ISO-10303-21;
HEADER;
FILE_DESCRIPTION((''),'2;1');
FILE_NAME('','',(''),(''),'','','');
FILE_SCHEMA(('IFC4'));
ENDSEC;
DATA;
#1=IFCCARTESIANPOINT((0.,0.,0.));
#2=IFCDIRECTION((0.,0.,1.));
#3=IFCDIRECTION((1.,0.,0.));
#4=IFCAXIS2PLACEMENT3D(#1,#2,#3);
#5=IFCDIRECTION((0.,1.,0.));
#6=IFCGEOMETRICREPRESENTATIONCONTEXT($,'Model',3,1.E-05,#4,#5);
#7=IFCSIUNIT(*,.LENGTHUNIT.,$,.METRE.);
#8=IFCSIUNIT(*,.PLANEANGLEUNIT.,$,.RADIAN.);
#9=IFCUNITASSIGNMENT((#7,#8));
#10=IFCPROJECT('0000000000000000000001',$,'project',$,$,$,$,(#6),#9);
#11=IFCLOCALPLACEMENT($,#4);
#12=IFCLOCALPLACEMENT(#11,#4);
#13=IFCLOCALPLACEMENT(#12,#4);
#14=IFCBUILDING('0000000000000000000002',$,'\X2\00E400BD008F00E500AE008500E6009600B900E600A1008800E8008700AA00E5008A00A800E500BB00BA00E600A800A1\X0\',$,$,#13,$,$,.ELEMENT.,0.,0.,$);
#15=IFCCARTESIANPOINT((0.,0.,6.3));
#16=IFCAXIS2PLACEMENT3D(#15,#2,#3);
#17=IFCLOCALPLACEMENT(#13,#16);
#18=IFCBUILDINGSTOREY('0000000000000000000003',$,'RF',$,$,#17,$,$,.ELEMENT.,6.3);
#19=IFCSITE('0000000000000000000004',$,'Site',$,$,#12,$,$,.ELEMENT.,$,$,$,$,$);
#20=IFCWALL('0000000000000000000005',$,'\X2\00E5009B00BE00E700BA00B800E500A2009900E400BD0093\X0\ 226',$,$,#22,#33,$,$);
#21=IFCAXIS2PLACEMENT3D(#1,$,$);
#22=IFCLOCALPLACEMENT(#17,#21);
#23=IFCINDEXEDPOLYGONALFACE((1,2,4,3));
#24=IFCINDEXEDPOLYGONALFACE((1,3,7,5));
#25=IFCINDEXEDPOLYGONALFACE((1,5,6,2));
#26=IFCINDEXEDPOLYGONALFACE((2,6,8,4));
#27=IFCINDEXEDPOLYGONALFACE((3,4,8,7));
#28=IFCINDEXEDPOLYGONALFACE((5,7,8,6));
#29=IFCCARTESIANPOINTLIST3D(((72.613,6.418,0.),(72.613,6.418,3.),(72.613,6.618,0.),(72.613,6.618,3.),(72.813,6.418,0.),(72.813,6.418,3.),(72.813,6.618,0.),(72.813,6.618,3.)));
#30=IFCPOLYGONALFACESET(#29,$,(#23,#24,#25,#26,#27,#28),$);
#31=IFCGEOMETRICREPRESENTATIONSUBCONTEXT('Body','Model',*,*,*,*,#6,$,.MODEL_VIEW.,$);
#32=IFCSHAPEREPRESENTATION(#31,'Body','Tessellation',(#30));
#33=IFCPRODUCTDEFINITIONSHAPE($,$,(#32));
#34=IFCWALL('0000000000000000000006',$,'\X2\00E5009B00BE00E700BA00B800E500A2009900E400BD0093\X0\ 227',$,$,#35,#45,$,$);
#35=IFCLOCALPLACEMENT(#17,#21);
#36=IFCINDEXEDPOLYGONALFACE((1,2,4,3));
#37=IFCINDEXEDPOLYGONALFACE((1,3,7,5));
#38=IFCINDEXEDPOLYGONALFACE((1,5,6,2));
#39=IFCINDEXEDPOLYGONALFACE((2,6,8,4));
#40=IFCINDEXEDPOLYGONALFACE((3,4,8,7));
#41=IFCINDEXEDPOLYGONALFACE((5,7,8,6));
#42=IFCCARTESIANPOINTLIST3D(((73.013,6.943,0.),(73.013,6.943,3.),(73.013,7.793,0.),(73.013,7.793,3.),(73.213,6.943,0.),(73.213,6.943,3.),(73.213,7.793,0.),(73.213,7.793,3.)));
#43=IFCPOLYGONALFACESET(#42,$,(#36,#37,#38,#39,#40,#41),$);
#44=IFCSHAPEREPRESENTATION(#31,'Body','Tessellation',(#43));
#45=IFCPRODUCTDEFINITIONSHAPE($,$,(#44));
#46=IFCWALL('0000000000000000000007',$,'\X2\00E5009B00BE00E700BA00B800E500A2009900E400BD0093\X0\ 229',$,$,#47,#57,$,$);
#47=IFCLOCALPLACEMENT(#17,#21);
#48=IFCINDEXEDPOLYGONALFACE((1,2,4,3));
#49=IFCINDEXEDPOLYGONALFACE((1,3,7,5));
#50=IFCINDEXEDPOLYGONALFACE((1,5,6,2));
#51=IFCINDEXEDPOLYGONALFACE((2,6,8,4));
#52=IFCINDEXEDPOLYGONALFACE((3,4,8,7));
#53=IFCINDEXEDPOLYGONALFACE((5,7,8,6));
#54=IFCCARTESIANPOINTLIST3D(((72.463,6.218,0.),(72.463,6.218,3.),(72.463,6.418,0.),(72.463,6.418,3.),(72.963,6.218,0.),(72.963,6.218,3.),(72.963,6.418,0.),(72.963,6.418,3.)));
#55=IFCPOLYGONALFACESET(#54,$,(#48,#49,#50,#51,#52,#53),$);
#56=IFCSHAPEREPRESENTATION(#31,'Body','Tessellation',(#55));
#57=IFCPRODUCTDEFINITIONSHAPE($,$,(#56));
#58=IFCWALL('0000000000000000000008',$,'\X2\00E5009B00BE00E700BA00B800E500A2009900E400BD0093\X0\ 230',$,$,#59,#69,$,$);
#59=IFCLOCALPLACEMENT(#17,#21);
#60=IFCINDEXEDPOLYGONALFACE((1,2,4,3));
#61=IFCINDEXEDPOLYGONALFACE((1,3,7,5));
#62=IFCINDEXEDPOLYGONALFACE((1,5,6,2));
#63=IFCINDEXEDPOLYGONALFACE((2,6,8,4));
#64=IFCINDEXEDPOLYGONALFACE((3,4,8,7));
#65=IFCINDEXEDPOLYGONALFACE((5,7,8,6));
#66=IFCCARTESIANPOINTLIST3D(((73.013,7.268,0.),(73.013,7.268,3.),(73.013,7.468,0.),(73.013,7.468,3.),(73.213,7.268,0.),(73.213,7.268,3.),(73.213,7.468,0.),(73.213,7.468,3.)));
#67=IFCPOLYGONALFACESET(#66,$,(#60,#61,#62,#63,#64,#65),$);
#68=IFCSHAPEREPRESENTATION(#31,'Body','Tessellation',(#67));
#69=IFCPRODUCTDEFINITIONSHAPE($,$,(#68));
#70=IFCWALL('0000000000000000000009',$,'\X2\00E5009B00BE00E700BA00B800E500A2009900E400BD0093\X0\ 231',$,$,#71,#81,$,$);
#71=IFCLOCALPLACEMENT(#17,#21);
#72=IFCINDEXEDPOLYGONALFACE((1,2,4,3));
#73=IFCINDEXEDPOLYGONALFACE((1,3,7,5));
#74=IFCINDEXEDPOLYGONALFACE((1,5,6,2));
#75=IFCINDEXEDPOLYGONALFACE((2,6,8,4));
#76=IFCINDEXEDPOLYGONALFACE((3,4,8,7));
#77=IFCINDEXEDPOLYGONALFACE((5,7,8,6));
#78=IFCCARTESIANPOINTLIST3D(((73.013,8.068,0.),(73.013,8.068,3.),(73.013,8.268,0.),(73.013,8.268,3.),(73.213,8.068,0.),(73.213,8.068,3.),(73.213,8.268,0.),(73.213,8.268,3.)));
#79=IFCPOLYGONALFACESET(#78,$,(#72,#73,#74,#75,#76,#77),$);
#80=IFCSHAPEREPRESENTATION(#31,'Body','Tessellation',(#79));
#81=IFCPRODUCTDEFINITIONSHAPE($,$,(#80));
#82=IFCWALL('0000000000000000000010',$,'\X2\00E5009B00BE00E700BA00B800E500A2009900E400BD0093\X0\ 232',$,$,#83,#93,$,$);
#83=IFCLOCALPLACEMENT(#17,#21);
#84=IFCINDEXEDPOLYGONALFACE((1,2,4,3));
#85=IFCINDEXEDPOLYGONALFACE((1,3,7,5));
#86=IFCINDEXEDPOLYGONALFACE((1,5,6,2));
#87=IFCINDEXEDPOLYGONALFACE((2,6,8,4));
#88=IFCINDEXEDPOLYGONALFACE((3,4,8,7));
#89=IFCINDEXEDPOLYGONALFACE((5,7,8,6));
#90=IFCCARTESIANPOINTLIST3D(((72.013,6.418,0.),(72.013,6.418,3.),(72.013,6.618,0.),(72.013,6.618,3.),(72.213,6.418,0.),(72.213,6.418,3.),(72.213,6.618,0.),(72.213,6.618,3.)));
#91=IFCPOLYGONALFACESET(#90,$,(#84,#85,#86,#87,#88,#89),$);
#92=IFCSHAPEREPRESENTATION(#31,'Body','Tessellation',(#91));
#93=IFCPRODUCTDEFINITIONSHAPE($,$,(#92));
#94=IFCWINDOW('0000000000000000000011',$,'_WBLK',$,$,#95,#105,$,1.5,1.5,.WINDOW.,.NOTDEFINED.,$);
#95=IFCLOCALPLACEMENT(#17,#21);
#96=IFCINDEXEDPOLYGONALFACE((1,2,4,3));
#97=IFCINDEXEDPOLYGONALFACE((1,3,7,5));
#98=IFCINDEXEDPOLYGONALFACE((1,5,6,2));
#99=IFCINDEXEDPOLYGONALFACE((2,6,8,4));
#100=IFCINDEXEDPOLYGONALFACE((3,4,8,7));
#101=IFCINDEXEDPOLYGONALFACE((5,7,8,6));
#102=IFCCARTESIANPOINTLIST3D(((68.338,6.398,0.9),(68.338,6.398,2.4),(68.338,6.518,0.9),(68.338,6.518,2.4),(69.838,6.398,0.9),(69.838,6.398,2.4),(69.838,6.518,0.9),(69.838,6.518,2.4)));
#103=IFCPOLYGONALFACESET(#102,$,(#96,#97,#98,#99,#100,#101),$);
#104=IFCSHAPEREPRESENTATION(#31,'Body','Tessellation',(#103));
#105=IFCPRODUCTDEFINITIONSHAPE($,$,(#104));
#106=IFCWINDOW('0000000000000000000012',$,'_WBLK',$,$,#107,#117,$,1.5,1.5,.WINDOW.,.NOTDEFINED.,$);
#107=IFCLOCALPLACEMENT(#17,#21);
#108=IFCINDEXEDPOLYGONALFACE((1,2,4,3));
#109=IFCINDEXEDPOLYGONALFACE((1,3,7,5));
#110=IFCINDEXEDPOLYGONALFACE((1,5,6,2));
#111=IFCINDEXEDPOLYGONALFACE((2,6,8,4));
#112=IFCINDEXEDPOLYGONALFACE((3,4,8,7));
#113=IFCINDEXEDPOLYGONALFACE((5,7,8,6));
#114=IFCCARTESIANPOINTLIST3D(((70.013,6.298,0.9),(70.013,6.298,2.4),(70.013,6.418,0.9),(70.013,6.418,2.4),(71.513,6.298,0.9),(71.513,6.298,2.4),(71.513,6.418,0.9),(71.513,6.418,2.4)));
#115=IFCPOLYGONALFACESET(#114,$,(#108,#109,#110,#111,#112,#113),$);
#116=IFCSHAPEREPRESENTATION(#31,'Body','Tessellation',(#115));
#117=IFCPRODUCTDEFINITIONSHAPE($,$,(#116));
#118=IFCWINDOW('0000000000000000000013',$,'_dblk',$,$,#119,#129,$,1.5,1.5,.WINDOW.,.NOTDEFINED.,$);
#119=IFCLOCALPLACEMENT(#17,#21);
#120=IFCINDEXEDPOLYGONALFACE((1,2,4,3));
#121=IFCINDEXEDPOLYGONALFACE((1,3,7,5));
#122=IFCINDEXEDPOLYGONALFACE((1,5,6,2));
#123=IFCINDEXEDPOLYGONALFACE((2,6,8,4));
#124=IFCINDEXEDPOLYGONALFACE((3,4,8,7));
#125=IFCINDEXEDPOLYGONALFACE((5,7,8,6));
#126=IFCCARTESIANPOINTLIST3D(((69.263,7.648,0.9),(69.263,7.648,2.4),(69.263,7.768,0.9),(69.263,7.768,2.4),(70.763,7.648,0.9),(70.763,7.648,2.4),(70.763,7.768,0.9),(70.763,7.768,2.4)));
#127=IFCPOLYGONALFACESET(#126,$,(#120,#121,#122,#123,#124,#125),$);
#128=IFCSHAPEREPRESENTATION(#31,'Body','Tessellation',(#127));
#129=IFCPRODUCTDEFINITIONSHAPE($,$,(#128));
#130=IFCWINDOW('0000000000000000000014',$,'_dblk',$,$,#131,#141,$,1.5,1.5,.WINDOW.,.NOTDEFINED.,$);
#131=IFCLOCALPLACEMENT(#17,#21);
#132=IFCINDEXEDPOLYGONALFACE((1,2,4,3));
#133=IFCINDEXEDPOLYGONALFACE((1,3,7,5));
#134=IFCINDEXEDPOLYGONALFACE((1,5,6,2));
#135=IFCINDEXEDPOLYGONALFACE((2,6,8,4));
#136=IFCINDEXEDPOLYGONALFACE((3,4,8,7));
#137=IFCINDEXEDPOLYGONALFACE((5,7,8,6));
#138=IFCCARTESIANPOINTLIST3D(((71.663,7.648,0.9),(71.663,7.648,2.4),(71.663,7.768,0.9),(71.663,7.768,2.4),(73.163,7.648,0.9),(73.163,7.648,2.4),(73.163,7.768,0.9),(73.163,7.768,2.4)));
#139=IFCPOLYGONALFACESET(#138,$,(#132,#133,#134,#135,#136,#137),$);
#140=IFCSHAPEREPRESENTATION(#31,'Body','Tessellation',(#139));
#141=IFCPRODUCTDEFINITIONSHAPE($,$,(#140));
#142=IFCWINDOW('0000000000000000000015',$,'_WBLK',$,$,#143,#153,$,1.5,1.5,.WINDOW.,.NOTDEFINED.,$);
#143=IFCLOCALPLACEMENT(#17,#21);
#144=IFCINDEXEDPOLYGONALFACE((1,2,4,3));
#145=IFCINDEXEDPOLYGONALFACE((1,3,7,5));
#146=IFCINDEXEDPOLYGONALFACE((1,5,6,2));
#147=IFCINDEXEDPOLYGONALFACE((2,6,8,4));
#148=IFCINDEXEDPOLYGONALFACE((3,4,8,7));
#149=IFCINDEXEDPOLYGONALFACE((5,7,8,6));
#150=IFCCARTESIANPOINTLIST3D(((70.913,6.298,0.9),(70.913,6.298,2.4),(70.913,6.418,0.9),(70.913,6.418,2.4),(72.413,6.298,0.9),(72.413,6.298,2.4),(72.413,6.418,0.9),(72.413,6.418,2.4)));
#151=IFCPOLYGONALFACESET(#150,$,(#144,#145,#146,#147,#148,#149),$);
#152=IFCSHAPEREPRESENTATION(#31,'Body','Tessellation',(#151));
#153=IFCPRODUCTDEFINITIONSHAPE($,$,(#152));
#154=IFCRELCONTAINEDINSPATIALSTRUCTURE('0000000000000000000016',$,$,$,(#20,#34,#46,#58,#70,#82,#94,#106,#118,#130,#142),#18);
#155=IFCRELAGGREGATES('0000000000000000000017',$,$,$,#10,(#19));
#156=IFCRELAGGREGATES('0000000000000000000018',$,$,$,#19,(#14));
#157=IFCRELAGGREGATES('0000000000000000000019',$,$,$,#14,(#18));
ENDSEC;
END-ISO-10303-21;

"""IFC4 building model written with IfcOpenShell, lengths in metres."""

from ifc_helpers import new_model, si_unit, direction, frame, frame_2d, origin_with_axes, place, context, subcontext, project, spatial, rectangle, extrude, element, save


model = new_model("IFC4")

# Units and contexts
model_context = context("Model", 3, precision=1e-05, world=origin_with_axes(), true_north=direction((0.0, 1.0, 0.0)))
body_context = subcontext(model_context, "Body", "Model", "MODEL_VIEW")
ifc_project = project(units=[si_unit("LENGTHUNIT", "METRE"), si_unit("PLANEANGLEUNIT", "RADIAN")], contexts=[model_context])

# Site, building, storey
placement = place(None, origin_with_axes())
site_placement = place(placement, origin_with_axes())
site = spatial("IfcSite", under=ifc_project, at=site_placement, Name="Site", CompositionType="ELEMENT")
building_placement = place(site_placement, origin_with_axes())
building = spatial("IfcBuilding", under=site, at=building_placement, Name="ä½\u008få®\u0085æ\u0096¹æ¡\u0088è\u0087ªå\u008a¨å»ºæ¨¡", CompositionType="ELEMENT", ElevationOfRefHeight=0.0, ElevationOfTerrain=0.0)
storey_placement = place(building_placement, frame((0.0, 0.0, 6.3), z_axis=(0.0, 0.0, 1.0), x_axis=(1.0, 0.0, 0.0)))
storey = spatial("IfcBuildingStorey", under=building, at=storey_placement, Name="RF", CompositionType="ELEMENT", Elevation=6.3)

# Walls
wall_1_placement = place(storey_placement, frame((72.713, 6.518, 0.0), z_axis=(0.0, 0.0, 1.0), x_axis=(0.0, -1.0, 0.0)))
element("IfcWall", 1, at=wall_1_placement, inside=storey, Name="å\u009b¾çº¸å¢\u0099ä½\u0093 226", context=body_context, shape_type="SweptSolid", body=[
    extrude(rectangle(XDim=0.2, YDim=0.2, at=frame_2d((0.0, 0.0), x_axis=(1.0, 0.0, 0.0))), frame((0.0, 0.0, 0.0), z_axis=(0.0, 0.0, 1.0)), (0.0, 0.0, 1.0), 3.0),
])
wall_2_placement = place(storey_placement, frame((73.113, 7.368, 0.0), z_axis=(0.0, 0.0, 1.0), x_axis=(0.0, -1.0, 0.0)))
element("IfcWall", 2, at=wall_2_placement, inside=storey, Name="å\u009b¾çº¸å¢\u0099ä½\u0093 227", context=body_context, shape_type="SweptSolid", body=[
    extrude(rectangle(XDim=0.85, YDim=0.2, at=frame_2d((0.0, 0.0), x_axis=(1.0, 0.0, 0.0))), frame((0.0, 0.0, 0.0), z_axis=(0.0, 0.0, 1.0)), (0.0, 0.0, 1.0), 3.0),
])
wall_3_placement = place(storey_placement, frame((72.713, 6.318, 0.0), z_axis=(0.0, 0.0, 1.0), x_axis=(1.0, 0.0, 0.0)))
element("IfcWall", 3, at=wall_3_placement, inside=storey, Name="å\u009b¾çº¸å¢\u0099ä½\u0093 229", context=body_context, shape_type="SweptSolid", body=[
    extrude(rectangle(XDim=0.5, YDim=0.2, at=frame_2d((0.0, 0.0), x_axis=(1.0, 0.0, 0.0))), frame((0.0, 0.0, 0.0), z_axis=(0.0, 0.0, 1.0)), (0.0, 0.0, 1.0), 3.0),
])
for number, where, z_axis, x_axis, name in (
    (4, (73.113, 7.368, 0.0), (0.0, 0.0, 1.0), (1.0, 0.0, 0.0), "å\u009b¾çº¸å¢\u0099ä½\u0093 230"),
    (5, (73.113, 8.168, 0.0), (0.0, 0.0, 1.0), (1.0, 0.0, 0.0), "å\u009b¾çº¸å¢\u0099ä½\u0093 231"),
    (6, (72.113, 6.518, 0.0), (0.0, 0.0, 1.0), (0.0, -1.0, 0.0), "å\u009b¾çº¸å¢\u0099ä½\u0093 232"),
):
    element("IfcWall", number, at=place(storey_placement, frame(where, z_axis=z_axis, x_axis=x_axis)), inside=storey, Name=name, context=body_context, shape_type="SweptSolid", body=[
        extrude(rectangle(XDim=0.2, YDim=0.2, at=frame_2d((0.0, 0.0), x_axis=(1.0, 0.0, 0.0))), frame((0.0, 0.0, 0.0), z_axis=(0.0, 0.0, 1.0)), (0.0, 0.0, 1.0), 3.0),
    ])

# Windows
for number, where, z_axis, x_axis, name in (
    (7, (69.088, 6.458, 0.9), (0.0, 0.0, 1.0), (1.0, 0.0, 0.0), "_WBLK"),
    (8, (70.763, 6.358, 0.9), (0.0, 0.0, 1.0), (1.0, 0.0, 0.0), "_WBLK"),
    (9, (70.013, 7.708, 0.9), (0.0, 0.0, 1.0), (1.0, 0.0, 0.0), "_dblk"),
    (10, (72.413, 7.708, 0.9), (0.0, 0.0, 1.0), (1.0, 0.0, 0.0), "_dblk"),
    (11, (71.663, 6.358, 0.9), (0.0, 0.0, 1.0), (1.0, 0.0, 0.0), "_WBLK"),
):
    element("IfcWindow", number, at=place(storey_placement, frame(where, z_axis=z_axis, x_axis=x_axis)), inside=storey, Name=name, OverallHeight=1.5, OverallWidth=1.5, PartitioningType="NOTDEFINED", PredefinedType="WINDOW", context=body_context, shape_type="SweptSolid", body=[
        extrude(rectangle(XDim=1.5, YDim=0.12, at=frame_2d((0.0, 0.0), x_axis=(1.0, 0.0, 0.0))), frame((0.0, 0.0, 0.0), z_axis=(0.0, 0.0, 1.0)), (0.0, 0.0, 1.0), 1.5),
    ])

save(model, "model.ifc")
